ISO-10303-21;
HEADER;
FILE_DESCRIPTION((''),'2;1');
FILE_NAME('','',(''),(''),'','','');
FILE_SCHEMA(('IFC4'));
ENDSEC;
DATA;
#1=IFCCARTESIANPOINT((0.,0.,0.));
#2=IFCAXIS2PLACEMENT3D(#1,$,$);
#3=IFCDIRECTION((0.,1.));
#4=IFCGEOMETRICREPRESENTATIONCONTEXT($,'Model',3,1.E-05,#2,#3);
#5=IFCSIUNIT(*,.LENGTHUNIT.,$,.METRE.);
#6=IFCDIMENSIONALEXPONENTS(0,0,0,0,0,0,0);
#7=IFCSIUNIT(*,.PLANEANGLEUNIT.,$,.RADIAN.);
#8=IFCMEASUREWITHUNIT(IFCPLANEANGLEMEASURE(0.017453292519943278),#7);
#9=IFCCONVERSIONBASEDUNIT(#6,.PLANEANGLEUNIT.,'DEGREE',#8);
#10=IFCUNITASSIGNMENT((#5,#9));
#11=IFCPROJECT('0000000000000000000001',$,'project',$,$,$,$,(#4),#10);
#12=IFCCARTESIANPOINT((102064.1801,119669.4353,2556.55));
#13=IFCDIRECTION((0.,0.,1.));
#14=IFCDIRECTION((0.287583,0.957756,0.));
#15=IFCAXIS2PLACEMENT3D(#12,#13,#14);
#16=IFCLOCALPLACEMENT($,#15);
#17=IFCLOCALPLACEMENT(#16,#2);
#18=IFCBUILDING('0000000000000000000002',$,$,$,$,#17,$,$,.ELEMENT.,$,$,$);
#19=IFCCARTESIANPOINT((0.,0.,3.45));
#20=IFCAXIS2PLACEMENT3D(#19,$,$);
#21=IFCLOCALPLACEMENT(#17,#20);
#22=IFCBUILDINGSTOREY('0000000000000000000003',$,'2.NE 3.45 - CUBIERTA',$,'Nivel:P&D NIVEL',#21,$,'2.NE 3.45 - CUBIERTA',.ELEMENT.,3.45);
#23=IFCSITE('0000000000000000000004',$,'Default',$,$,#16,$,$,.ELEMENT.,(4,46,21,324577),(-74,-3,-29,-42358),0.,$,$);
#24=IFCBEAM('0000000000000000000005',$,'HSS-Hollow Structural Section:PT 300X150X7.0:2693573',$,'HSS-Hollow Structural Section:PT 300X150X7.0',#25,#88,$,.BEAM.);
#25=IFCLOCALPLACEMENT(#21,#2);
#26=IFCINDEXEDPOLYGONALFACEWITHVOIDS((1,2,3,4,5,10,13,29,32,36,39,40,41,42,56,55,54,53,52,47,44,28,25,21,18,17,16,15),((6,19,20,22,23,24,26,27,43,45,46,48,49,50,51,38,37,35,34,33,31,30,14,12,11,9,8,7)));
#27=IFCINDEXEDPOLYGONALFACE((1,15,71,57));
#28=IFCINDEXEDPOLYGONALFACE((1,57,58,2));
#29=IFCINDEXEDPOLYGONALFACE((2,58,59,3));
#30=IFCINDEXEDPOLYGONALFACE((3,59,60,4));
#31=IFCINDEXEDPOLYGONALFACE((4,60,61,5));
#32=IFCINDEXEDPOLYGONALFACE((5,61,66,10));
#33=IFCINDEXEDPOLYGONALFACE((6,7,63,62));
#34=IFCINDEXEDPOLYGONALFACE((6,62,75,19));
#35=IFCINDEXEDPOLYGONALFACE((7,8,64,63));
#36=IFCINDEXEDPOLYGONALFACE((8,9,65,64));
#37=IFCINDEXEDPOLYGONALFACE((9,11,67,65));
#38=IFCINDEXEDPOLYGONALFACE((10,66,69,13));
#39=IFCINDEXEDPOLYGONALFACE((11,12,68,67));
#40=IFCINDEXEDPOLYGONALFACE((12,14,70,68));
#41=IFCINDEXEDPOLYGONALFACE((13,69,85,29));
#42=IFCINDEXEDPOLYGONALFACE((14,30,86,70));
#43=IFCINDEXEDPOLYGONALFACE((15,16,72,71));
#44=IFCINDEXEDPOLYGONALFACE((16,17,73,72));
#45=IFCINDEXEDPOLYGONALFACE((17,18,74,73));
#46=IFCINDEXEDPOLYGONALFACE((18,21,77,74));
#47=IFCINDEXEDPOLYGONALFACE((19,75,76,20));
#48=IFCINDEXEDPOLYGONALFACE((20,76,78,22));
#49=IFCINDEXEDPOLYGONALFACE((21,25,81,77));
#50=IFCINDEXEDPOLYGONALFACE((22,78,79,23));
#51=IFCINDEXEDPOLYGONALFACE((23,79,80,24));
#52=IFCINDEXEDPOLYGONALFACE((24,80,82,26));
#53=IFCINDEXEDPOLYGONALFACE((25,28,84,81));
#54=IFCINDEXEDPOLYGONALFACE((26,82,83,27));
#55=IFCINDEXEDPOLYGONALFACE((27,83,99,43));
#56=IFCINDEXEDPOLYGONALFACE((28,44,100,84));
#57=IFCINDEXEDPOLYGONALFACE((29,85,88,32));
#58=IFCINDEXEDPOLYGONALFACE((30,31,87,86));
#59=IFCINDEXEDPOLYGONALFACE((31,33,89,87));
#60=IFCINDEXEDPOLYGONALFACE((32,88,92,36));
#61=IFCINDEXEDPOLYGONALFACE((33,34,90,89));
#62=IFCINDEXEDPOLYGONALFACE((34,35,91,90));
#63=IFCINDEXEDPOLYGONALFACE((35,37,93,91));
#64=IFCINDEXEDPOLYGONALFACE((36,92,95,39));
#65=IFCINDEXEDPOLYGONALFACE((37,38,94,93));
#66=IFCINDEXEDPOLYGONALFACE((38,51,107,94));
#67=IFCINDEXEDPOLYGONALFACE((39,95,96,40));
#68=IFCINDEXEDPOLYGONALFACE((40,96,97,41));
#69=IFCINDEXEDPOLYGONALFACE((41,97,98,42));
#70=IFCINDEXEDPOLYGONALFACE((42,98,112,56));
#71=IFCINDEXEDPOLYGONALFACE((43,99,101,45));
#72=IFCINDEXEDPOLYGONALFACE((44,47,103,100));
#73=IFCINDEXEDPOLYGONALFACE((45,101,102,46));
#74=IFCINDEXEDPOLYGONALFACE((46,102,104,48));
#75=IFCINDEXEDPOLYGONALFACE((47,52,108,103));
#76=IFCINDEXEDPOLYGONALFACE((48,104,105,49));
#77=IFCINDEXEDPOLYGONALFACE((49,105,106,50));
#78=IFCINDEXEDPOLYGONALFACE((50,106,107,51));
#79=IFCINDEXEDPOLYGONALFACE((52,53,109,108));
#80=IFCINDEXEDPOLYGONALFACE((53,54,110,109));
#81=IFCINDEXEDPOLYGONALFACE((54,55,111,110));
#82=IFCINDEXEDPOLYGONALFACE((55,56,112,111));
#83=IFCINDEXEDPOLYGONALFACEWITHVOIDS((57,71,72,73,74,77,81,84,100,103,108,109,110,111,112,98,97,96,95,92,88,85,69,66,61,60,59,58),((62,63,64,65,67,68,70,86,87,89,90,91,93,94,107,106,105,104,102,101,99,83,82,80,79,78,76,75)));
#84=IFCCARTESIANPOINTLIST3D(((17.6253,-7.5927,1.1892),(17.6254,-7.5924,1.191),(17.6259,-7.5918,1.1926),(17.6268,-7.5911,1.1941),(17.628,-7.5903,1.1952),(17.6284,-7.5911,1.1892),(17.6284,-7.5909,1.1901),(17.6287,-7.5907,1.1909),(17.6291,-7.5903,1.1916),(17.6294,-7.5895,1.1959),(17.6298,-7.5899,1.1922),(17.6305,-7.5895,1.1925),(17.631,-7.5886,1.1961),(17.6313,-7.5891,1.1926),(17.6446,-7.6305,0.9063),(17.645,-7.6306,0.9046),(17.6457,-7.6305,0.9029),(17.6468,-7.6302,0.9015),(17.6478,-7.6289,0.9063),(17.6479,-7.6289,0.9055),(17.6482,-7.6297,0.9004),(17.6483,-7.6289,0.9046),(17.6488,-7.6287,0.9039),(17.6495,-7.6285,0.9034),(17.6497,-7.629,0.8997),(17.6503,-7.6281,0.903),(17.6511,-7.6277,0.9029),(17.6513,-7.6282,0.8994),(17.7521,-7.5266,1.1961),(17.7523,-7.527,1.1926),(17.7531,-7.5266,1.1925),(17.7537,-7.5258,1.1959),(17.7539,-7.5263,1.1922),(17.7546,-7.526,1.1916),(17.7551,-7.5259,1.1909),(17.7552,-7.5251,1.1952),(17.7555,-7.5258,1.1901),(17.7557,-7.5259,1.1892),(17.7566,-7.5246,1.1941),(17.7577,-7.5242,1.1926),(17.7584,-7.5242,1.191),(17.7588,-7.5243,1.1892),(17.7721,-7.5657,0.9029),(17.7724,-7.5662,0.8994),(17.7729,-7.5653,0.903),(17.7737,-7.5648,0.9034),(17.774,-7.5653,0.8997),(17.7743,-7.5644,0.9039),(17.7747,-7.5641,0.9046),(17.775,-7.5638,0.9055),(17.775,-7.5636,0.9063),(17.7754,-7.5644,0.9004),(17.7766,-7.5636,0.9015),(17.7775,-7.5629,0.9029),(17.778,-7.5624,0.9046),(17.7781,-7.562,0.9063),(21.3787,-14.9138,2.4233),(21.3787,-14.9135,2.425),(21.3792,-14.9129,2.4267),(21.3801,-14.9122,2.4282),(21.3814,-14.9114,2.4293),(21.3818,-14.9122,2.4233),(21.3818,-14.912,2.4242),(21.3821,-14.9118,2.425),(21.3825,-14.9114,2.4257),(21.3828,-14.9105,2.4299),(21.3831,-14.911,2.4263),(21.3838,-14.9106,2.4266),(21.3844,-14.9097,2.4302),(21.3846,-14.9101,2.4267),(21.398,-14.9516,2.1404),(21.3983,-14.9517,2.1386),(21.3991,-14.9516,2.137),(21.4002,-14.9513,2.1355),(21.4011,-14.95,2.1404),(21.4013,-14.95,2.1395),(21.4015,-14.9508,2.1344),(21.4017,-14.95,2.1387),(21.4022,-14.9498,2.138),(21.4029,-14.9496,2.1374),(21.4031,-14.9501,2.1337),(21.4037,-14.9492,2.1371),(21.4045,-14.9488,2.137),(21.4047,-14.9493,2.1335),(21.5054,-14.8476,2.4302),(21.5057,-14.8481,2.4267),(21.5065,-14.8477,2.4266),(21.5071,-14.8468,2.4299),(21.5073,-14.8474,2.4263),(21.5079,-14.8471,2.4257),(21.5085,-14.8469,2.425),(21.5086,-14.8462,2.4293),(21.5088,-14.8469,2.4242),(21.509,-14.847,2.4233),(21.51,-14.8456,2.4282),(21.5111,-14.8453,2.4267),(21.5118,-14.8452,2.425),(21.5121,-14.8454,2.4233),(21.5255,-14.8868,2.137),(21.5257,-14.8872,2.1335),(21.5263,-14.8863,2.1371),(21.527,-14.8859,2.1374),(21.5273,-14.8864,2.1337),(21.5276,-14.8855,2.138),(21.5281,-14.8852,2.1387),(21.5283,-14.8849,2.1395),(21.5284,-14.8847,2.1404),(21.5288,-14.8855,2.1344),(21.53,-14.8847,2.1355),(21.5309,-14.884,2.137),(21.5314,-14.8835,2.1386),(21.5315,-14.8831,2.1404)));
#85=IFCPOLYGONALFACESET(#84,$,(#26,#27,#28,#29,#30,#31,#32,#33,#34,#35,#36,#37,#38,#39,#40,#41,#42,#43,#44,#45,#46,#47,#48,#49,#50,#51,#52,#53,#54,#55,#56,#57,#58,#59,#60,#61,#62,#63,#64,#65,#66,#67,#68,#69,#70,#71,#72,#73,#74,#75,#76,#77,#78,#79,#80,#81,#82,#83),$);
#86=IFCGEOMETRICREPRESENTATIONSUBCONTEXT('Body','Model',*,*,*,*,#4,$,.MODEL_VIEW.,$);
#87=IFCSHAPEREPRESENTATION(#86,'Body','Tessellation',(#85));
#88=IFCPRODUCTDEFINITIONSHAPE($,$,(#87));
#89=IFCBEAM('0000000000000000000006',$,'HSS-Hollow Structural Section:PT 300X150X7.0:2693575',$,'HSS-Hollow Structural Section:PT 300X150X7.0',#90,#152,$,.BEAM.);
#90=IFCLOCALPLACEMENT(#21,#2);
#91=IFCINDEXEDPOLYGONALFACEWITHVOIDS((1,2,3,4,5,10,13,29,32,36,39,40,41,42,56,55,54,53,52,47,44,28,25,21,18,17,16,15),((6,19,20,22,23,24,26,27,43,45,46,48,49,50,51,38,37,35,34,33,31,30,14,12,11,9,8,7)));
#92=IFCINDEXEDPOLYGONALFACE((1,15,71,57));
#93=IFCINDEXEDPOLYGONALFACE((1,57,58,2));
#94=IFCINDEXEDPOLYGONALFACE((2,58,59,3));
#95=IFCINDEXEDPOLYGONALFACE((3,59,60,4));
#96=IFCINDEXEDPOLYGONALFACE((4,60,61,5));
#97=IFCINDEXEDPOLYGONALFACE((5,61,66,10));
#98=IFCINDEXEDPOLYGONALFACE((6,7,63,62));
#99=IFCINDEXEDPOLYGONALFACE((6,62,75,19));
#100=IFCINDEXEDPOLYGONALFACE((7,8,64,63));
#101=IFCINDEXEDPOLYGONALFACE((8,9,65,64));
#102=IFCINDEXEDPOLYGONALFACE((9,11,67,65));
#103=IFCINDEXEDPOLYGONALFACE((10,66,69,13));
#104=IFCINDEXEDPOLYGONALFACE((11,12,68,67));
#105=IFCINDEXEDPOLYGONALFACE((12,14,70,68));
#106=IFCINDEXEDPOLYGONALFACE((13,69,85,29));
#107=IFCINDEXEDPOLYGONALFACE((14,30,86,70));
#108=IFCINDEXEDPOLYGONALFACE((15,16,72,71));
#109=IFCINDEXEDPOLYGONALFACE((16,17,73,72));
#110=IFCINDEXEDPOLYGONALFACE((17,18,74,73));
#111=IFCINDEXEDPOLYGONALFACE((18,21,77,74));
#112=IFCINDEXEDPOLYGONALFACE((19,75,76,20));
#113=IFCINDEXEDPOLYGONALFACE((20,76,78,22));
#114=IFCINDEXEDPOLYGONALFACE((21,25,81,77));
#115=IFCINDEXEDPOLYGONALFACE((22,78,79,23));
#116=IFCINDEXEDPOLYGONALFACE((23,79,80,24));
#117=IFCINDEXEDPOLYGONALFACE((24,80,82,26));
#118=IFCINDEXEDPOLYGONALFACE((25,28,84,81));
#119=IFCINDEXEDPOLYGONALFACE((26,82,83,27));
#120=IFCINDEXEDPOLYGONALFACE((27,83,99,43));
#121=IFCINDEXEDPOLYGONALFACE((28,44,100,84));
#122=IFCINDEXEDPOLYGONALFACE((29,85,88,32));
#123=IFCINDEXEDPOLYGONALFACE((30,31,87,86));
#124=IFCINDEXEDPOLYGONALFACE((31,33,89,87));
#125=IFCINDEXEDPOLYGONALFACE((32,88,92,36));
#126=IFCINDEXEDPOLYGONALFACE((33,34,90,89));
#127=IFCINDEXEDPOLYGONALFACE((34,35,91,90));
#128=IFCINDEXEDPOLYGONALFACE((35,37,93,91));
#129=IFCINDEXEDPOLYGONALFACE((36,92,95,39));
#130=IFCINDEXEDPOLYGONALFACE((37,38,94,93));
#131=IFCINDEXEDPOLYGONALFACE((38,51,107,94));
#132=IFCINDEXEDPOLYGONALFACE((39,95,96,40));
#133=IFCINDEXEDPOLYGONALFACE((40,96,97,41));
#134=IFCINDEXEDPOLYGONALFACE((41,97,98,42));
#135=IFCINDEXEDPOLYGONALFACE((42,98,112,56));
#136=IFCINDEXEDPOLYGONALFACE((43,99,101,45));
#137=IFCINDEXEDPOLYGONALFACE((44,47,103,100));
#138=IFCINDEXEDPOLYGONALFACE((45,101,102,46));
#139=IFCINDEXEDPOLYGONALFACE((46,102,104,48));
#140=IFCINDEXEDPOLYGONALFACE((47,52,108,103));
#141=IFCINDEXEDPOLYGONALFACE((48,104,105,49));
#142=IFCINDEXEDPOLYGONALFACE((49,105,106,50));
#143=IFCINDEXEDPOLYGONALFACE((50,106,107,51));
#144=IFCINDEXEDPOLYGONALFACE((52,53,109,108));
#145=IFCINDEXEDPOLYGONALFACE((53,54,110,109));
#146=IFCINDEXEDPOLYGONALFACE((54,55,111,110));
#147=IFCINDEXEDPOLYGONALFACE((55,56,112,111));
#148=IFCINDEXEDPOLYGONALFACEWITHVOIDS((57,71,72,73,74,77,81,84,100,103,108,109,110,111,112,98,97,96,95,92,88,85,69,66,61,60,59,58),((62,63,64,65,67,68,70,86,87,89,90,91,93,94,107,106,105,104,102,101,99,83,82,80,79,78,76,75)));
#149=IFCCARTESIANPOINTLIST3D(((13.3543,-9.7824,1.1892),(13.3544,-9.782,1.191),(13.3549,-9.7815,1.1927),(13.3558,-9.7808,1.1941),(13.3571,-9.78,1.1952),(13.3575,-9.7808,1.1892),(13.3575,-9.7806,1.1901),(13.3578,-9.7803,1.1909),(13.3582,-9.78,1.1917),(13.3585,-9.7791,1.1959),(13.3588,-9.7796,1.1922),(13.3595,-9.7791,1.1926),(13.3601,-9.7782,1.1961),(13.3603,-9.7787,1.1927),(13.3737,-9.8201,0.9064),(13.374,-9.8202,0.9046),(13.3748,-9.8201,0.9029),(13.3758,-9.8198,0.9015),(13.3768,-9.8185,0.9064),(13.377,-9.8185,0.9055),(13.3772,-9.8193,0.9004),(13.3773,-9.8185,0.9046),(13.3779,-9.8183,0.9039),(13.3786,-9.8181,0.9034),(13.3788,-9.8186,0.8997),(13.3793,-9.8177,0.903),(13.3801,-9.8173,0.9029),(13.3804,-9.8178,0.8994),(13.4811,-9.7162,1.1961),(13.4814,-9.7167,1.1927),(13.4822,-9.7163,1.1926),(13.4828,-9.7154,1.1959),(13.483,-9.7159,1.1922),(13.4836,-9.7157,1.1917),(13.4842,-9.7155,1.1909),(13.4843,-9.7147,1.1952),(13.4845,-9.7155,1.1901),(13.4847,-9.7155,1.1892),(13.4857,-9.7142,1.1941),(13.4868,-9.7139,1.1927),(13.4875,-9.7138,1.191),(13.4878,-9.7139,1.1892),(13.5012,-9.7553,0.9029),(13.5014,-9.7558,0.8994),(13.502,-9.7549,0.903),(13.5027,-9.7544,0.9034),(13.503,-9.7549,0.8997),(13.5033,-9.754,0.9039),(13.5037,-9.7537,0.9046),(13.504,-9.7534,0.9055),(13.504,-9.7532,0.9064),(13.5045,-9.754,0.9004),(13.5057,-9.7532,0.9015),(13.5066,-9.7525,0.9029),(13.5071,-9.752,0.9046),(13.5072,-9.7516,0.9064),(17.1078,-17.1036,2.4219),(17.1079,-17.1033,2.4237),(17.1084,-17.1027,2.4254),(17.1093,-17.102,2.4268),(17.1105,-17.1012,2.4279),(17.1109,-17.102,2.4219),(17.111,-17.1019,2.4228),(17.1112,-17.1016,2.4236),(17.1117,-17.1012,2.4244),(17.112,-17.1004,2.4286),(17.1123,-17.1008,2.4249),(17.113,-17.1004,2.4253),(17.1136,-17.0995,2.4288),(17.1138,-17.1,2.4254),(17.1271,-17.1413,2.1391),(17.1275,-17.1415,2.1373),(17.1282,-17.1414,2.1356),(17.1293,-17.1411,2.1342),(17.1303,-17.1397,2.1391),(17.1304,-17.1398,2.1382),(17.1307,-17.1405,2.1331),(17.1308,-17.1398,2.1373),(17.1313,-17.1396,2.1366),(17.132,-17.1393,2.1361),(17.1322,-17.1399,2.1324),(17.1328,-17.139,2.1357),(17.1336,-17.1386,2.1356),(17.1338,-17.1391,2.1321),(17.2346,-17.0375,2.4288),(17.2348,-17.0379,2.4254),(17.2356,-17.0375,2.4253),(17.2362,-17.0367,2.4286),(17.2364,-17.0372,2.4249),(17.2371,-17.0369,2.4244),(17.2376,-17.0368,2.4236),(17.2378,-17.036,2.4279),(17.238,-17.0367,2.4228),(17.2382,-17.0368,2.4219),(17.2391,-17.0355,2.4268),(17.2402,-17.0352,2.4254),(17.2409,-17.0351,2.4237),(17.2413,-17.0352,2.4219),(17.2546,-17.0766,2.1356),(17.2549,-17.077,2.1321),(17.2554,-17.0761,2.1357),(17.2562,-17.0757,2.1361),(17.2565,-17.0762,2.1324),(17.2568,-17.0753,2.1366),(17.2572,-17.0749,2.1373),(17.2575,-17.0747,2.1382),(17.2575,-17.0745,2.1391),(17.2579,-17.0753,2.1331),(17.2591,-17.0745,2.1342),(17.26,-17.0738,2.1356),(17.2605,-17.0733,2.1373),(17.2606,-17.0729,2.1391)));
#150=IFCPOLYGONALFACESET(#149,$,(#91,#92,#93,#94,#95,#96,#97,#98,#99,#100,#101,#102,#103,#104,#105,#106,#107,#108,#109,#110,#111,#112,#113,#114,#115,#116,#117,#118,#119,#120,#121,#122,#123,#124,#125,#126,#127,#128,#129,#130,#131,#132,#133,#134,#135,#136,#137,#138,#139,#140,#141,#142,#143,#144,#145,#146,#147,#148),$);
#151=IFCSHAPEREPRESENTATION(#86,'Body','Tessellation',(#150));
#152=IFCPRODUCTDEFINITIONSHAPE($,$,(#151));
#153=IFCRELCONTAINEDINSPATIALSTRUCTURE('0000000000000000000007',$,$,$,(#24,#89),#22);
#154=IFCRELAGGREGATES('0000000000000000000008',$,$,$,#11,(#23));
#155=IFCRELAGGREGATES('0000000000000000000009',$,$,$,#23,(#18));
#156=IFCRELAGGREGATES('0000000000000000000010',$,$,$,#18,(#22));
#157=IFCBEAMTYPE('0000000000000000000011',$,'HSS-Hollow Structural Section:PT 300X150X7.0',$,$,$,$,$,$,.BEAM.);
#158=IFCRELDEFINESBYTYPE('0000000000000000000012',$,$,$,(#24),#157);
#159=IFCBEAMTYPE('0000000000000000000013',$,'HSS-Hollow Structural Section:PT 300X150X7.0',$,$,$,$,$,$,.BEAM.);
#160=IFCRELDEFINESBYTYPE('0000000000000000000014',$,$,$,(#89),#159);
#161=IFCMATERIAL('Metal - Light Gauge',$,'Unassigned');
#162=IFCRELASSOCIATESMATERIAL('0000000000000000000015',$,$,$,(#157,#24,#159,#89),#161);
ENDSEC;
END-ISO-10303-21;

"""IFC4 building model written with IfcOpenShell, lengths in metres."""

from ifc_helpers import new_model, entity, si_unit, converted_unit, direction, frame, origin, place, context, subcontext, project, spatial, line, arc, indexed_curve, outline, extrude, source, transform, mapped, material, type_object, type_shapes, element, save


model = new_model("IFC4")

# Units and contexts
model_context = context("Model", 3, precision=1e-05, world=origin(), true_north=direction((0.0, 1.0)))
body_context = subcontext(model_context, "Body", "Model", "MODEL_VIEW")
ifc_project = project(units=[si_unit("LENGTHUNIT", "METRE"), converted_unit("PLANEANGLEUNIT", "DEGREE", entity("IfcPlaneAngleMeasure", 0.017453292519943278), si_unit("PLANEANGLEUNIT", "RADIAN"), dimensions=[0, 0, 0, 0, 0, 0, 0])], contexts=[model_context])

# Site, building, storey
site_placement = place(None, frame((102064.1801, 119669.4353, 2556.55), z_axis=(0.0, 0.0, 1.0), x_axis=(0.287583, 0.957756, 0.0)))
site = spatial("IfcSite", under=ifc_project, at=site_placement, Name="Default", CompositionType="ELEMENT", RefLatitude=(4, 46, 21, 324577), RefLongitude=(-74, -3, -29, -42358), RefElevation=0.0)
building_placement = place(site_placement, origin())
building = spatial("IfcBuilding", under=site, at=building_placement, CompositionType="ELEMENT")
storey_placement = place(building_placement, frame((0.0, 0.0, 3.45)))
storey = spatial("IfcBuildingStorey", under=building, at=storey_placement, Name="2.NE 3.45 - CUBIERTA", ObjectType="Nivel:P&D NIVEL", LongName="2.NE 3.45 - CUBIERTA", CompositionType="ELEMENT", Elevation=3.45)

# Beams
ifc_material_1 = material(Name="Metal - Light Gauge", Category="Unassigned")
beam_type_1 = type_object("IfcBeamType", Name="HSS-Hollow Structural Section:PT 300X150X7.0", PredefinedType="BEAM", material=ifc_material_1)
shared_shape_1 = source(origin(), body_context, "Body", "SweptSolid", [
    extrude(outline(indexed_curve([(0.143, -0.075), (0.1479, -0.0729), (0.15, -0.068), (0.15, 0.068), (0.1479, 0.0729), (0.143, 0.075), (-0.143, 0.075), (-0.1479, 0.0729), (-0.15, 0.068), (-0.15, -0.068), (-0.1479, -0.0729), (-0.143, -0.075)], segments=[arc(1, 2, 3), line(3, 4), arc(4, 5, 6), line(6, 7), arc(7, 8, 9), line(9, 10), arc(10, 11, 12), line(12, 1)], self_intersect=False), holes=[indexed_curve([(0.1465, 0.068), (0.1465, -0.068), (0.1455, -0.0705), (0.143, -0.0715), (-0.143, -0.0715), (-0.1455, -0.0705), (-0.1465, -0.068), (-0.1465, 0.068), (-0.1455, 0.0705), (-0.143, 0.0715), (0.143, 0.0715), (0.1455, 0.0705)], segments=[line(1, 2), arc(2, 3, 4), line(4, 5), arc(5, 6, 7), line(7, 8), arc(8, 9, 10), line(10, 11), arc(11, 12, 1)], self_intersect=False)]), frame((21.4551, -14.8985, 5.7318), z_axis=(-0.451169, 0.880024, -0.14834), x_axis=(-0.067675, 0.132004, 0.988936)), (0.0, 0.0, 1.0), 8.3192),
])
type_shapes(beam_type_1, [shared_shape_1])
beam_1_placement = place(storey_placement, frame((0.0, 0.0, -3.45)))
element("IfcBeam", 1, at=beam_1_placement, inside=storey, type_object=beam_type_1, material=ifc_material_1, Name="HSS-Hollow Structural Section:PT 300X150X7.0:2693573", ObjectType="HSS-Hollow Structural Section:PT 300X150X7.0", PredefinedType="BEAM", context=body_context, shape_type="MappedRepresentation", body=[
    mapped(shared_shape_1, transform((0.0, 0.0, 0.0), scale=1.0)),
])
beam_type_2 = type_object("IfcBeamType", Name="HSS-Hollow Structural Section:PT 300X150X7.0", PredefinedType="BEAM", material=ifc_material_1)
shared_shape_2 = source(origin(), body_context, "Body", "SweptSolid", [
    extrude(outline(indexed_curve([(0.143, -0.075), (0.1479, -0.0729), (0.15, -0.068), (0.15, 0.068), (0.1479, 0.0729), (0.143, 0.075), (-0.143, 0.075), (-0.1479, 0.0729), (-0.15, 0.068), (-0.15, -0.068), (-0.1479, -0.0729), (-0.143, -0.075)], segments=[arc(1, 2, 3), line(3, 4), arc(4, 5, 6), line(6, 7), arc(7, 8, 9), line(9, 10), arc(10, 11, 12), line(12, 1)], self_intersect=False), holes=[indexed_curve([(0.1465, 0.068), (0.1465, -0.068), (0.1455, -0.0705), (0.143, -0.0715), (-0.143, -0.0715), (-0.1455, -0.0705), (-0.1465, -0.068), (-0.1465, 0.068), (-0.1455, 0.0705), (-0.143, 0.0715), (0.143, 0.0715), (0.1455, 0.0705)], segments=[line(1, 2), arc(2, 3, 4), line(4, 5), arc(5, 6, 7), line(7, 8), arc(8, 9, 10), line(10, 11), arc(11, 12, 1)], self_intersect=False)]), frame((17.1842, -17.0883, 5.7305), z_axis=(-0.45118, 0.880046, -0.148176), x_axis=(-0.0676, 0.131857, 0.988961)), (0.0, 0.0, 1.0), 8.3192),
])
type_shapes(beam_type_2, [shared_shape_2])
beam_2_placement = place(storey_placement, frame((0.0, 0.0, -3.45)))
element("IfcBeam", 2, at=beam_2_placement, inside=storey, type_object=beam_type_2, material=ifc_material_1, Name="HSS-Hollow Structural Section:PT 300X150X7.0:2693575", ObjectType="HSS-Hollow Structural Section:PT 300X150X7.0", PredefinedType="BEAM", context=body_context, shape_type="MappedRepresentation", body=[
    mapped(shared_shape_2, transform((0.0, 0.0, 0.0), scale=1.0)),
])

save(model, "model.ifc")
